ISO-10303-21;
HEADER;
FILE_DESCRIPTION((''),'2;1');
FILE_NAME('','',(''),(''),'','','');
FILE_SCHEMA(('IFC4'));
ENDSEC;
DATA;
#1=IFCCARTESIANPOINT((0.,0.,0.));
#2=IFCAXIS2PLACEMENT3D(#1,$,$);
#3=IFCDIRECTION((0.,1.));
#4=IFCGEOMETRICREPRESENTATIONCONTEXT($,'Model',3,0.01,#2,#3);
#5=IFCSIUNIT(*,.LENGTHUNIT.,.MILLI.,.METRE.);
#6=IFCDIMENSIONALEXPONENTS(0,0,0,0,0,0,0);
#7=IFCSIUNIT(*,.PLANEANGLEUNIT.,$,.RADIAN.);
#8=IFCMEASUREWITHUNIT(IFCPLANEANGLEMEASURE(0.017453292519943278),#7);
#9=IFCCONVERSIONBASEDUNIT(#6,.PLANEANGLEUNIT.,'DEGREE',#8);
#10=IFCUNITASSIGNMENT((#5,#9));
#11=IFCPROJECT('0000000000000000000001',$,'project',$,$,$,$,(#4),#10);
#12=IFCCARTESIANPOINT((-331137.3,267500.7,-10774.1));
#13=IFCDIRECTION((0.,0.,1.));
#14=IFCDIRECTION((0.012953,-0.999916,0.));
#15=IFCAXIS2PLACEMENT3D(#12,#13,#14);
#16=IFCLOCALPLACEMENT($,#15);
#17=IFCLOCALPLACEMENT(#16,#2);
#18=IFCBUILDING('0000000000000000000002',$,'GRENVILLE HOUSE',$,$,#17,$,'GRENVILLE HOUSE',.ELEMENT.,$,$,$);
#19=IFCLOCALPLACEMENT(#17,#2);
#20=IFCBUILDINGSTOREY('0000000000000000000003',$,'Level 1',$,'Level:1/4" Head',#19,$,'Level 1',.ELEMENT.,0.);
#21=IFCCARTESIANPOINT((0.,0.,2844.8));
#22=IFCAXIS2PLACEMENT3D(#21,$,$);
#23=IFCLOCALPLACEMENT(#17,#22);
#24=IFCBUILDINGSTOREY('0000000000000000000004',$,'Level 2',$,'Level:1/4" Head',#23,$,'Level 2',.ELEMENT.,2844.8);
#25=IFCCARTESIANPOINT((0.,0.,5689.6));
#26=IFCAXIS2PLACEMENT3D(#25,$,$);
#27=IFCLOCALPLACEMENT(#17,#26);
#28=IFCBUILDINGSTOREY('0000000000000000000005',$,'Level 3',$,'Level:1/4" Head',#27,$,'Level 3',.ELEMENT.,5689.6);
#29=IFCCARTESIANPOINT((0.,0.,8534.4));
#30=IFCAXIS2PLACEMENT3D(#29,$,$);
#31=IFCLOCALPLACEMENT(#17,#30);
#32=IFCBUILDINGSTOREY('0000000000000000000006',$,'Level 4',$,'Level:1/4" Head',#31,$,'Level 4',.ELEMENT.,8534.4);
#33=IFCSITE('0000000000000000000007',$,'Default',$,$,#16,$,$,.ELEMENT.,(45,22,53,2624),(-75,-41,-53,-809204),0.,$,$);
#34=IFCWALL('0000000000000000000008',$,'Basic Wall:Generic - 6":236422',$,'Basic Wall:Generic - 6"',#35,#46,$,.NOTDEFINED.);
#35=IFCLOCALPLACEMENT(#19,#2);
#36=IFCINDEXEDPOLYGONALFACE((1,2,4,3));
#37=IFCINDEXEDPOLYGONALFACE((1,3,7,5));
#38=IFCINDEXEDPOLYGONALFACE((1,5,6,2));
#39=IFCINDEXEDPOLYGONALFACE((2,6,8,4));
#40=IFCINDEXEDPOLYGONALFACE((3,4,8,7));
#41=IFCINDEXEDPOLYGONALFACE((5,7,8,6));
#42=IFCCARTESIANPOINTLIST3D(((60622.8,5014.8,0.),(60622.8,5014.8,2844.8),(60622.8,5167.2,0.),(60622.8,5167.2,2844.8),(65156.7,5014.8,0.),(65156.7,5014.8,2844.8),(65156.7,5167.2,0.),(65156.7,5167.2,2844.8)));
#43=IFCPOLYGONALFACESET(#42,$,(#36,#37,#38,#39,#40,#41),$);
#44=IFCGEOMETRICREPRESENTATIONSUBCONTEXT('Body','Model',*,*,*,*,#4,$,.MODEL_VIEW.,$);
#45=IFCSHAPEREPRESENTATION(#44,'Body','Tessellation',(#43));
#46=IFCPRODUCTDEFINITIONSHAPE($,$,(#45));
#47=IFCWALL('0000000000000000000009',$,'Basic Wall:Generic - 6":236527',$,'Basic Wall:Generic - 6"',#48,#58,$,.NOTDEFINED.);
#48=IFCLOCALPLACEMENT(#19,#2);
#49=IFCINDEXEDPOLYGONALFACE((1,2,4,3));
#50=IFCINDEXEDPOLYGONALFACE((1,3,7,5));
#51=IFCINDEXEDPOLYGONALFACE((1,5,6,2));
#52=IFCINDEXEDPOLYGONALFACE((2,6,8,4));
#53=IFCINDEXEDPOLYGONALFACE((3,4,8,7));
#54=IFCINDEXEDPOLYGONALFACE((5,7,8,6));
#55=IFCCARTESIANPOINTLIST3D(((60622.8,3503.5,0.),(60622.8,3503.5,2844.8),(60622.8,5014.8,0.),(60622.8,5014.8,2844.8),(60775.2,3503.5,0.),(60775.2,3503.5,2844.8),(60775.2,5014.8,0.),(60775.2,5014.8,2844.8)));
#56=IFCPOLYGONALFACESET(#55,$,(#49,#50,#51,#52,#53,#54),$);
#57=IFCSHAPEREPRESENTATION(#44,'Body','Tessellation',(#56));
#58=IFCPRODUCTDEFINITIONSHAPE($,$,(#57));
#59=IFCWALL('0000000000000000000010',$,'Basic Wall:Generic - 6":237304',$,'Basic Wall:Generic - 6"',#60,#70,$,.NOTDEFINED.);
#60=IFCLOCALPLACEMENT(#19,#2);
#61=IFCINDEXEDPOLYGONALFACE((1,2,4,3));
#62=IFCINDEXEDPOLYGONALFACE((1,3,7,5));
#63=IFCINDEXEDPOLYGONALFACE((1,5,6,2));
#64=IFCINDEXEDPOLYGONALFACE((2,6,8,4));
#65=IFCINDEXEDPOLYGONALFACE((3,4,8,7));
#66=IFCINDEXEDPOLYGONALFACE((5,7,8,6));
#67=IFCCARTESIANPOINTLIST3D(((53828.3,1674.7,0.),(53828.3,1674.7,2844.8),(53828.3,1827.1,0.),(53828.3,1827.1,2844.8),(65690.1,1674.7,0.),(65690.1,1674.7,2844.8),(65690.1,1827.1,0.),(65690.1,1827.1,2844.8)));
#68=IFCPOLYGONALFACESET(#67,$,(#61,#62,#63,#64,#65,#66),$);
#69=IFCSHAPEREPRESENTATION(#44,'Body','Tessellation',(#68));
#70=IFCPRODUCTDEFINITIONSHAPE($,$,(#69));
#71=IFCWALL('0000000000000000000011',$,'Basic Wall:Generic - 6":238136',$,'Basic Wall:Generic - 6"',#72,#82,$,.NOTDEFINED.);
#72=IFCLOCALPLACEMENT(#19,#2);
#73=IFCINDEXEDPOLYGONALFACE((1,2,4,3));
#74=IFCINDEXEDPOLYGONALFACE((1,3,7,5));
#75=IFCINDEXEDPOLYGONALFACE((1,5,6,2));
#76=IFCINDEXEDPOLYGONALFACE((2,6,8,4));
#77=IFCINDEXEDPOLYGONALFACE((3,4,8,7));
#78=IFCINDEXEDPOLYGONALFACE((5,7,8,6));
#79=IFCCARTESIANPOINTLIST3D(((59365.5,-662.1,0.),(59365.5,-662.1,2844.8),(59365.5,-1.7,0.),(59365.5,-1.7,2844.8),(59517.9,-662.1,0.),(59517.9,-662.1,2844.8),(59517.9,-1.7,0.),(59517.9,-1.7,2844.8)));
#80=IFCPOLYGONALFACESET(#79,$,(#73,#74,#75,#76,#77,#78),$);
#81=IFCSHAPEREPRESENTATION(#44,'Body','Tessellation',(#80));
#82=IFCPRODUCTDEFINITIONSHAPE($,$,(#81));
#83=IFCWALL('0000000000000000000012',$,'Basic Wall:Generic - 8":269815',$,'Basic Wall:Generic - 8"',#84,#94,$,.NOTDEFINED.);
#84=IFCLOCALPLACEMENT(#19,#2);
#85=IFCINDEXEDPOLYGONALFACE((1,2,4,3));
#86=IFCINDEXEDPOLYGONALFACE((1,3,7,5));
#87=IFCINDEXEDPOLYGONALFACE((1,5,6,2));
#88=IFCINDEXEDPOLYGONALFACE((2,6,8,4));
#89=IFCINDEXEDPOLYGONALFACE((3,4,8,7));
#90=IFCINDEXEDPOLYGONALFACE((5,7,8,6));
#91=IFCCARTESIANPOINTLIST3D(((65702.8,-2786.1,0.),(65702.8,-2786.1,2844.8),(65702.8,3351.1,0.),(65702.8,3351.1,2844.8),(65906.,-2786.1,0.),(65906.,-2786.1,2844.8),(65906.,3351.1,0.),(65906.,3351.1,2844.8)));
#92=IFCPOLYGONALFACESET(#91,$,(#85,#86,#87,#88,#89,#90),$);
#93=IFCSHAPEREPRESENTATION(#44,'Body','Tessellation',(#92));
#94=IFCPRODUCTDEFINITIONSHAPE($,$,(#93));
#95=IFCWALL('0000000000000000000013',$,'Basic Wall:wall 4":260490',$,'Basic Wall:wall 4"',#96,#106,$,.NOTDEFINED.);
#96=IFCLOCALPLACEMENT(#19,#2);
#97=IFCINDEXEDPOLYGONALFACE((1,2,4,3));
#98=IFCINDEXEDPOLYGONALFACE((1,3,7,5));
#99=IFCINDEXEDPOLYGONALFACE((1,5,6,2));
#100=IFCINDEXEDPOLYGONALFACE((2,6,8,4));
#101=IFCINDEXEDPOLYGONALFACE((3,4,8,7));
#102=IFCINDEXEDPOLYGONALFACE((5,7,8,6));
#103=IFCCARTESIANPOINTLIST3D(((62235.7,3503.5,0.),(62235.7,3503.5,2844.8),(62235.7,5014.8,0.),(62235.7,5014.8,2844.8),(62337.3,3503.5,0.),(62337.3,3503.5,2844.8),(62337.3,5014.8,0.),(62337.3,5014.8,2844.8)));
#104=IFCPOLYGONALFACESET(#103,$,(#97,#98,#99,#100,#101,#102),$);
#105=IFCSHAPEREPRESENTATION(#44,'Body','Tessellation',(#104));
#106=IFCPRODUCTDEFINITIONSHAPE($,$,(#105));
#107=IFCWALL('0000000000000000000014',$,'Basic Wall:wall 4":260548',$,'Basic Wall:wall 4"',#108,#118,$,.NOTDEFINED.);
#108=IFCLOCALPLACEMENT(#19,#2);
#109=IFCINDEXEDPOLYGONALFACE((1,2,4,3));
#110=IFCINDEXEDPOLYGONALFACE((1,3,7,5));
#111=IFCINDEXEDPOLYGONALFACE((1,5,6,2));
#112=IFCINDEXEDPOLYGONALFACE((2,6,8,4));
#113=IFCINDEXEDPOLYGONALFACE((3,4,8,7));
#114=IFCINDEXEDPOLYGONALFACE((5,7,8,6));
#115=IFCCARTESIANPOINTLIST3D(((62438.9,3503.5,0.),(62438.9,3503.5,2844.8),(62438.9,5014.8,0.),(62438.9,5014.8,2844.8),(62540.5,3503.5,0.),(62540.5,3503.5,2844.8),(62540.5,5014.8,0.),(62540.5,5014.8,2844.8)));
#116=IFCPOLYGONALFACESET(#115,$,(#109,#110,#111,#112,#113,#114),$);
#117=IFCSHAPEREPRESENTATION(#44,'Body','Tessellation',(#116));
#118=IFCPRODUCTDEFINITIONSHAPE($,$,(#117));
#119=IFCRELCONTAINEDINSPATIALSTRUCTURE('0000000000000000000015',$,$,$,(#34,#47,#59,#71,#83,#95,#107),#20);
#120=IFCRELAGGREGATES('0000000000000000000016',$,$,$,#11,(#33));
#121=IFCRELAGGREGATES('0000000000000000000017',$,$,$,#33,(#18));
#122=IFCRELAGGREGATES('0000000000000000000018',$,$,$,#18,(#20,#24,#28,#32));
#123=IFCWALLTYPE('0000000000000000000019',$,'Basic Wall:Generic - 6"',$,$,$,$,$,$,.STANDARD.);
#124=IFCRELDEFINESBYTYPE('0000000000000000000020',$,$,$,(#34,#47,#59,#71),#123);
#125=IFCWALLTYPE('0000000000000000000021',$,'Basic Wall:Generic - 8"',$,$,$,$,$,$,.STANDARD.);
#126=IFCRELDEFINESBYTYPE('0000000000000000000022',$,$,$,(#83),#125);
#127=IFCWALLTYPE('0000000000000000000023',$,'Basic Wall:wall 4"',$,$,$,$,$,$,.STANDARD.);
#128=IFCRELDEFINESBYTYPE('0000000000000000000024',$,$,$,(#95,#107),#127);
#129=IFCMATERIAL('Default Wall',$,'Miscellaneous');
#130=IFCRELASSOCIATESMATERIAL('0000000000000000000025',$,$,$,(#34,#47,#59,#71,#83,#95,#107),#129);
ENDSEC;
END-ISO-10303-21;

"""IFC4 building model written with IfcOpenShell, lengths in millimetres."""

from ifc_helpers import new_model, entity, si_unit, converted_unit, direction, frame, origin, place, context, subcontext, project, spatial, indexed_curve, outline, extrude, material, type_object, element, save


model = new_model("IFC4")

# Units and contexts
model_context = context("Model", 3, precision=0.01, world=origin(), true_north=direction((0.0, 1.0)))
body_context = subcontext(model_context, "Body", "Model", "MODEL_VIEW")
ifc_project = project(units=[si_unit("LENGTHUNIT", "METRE", prefix="MILLI"), converted_unit("PLANEANGLEUNIT", "DEGREE", entity("IfcPlaneAngleMeasure", 0.017453292519943278), si_unit("PLANEANGLEUNIT", "RADIAN"), dimensions=[0, 0, 0, 0, 0, 0, 0])], contexts=[model_context])

# Site, building, storey
site_placement = place(None, frame((-331137.3, 267500.7, -10774.1), z_axis=(0.0, 0.0, 1.0), x_axis=(0.012953, -0.999916, 0.0)))
site = spatial("IfcSite", under=ifc_project, at=site_placement, Name="Default", CompositionType="ELEMENT", RefLatitude=(45, 22, 53, 2624), RefLongitude=(-75, -41, -53, -809204), RefElevation=0.0)
building_placement = place(site_placement, origin())
building = spatial("IfcBuilding", under=site, at=building_placement, Name="GRENVILLE HOUSE", LongName="GRENVILLE HOUSE", CompositionType="ELEMENT")
storey_1_placement = place(building_placement, origin())
storey_1 = spatial("IfcBuildingStorey", under=building, at=storey_1_placement, Name="Level 1", ObjectType="Level:1/4\" Head", LongName="Level 1", CompositionType="ELEMENT", Elevation=0.0)

# Shared definitions
storey_2_placement = place(building_placement, frame((0.0, 0.0, 2844.8)))
storey_2 = spatial("IfcBuildingStorey", under=building, at=storey_2_placement, Name="Level 2", ObjectType="Level:1/4\" Head", LongName="Level 2", CompositionType="ELEMENT", Elevation=2844.8)

# Shared definitions
storey_3_placement = place(building_placement, frame((0.0, 0.0, 5689.6)))
storey_3 = spatial("IfcBuildingStorey", under=building, at=storey_3_placement, Name="Level 3", ObjectType="Level:1/4\" Head", LongName="Level 3", CompositionType="ELEMENT", Elevation=5689.6)

# Shared definitions
storey_4_placement = place(building_placement, frame((0.0, 0.0, 8534.4)))
storey_4 = spatial("IfcBuildingStorey", under=building, at=storey_4_placement, Name="Level 4", ObjectType="Level:1/4\" Head", LongName="Level 4", CompositionType="ELEMENT", Elevation=8534.4)

# Walls
ifc_material_1 = material(Name="Default Wall", Category="Miscellaneous")
wall_type_1 = type_object("IfcWallType", Name="Basic Wall:Generic - 6\"", PredefinedType="STANDARD")
wall_1_placement = place(storey_1_placement, frame((65156.7, 5091.0, 0.0), z_axis=(0.0, 0.0, 1.0), x_axis=(-1.0, 0.0, 0.0)))
element("IfcWall", 1, at=wall_1_placement, inside=storey_1, type_object=wall_type_1, material=ifc_material_1, Name="Basic Wall:Generic - 6\":236422", ObjectType="Basic Wall:Generic - 6\"", PredefinedType="NOTDEFINED", context=body_context, shape_type="SweptSolid", body=[
    extrude(outline(indexed_curve([(4533.9, 76.2), (0.0, 76.2), (0.0, -76.2), (4533.9, -76.2), (4533.9, 76.2)], self_intersect=False)), origin(), (0.0, 0.0, 1.0), 2844.8),
])
wall_2_placement = place(storey_1_placement, frame((60699.0, 5014.8, 0.0), z_axis=(0.0, 0.0, 1.0), x_axis=(0.0, -1.0, 0.0)))
element("IfcWall", 2, at=wall_2_placement, inside=storey_1, type_object=wall_type_1, material=ifc_material_1, Name="Basic Wall:Generic - 6\":236527", ObjectType="Basic Wall:Generic - 6\"", PredefinedType="NOTDEFINED", context=body_context, shape_type="SweptSolid", body=[
    extrude(outline(indexed_curve([(1511.3, 76.2), (0.0, 76.2), (0.0, -76.2), (1511.3, -76.2), (1511.3, 76.2)], self_intersect=False)), origin(), (0.0, 0.0, 1.0), 2844.8),
])
wall_3_placement = place(storey_1_placement, frame((65690.1, 1750.9, 0.0), z_axis=(0.0, 0.0, 1.0), x_axis=(-1.0, 0.0, 0.0)))
element("IfcWall", 3, at=wall_3_placement, inside=storey_1, type_object=wall_type_1, material=ifc_material_1, Name="Basic Wall:Generic - 6\":237304", ObjectType="Basic Wall:Generic - 6\"", PredefinedType="NOTDEFINED", context=body_context, shape_type="SweptSolid", body=[
    extrude(outline(indexed_curve([(11861.8, 76.2), (0.0, 76.2), (0.0, -76.2), (11861.8, -76.2), (11861.8, 76.2)], self_intersect=False)), origin(), (0.0, 0.0, 1.0), 2844.8),
])
wall_4_placement = place(storey_1_placement, frame((59441.7, -662.1, 0.0), z_axis=(0.0, 0.0, 1.0), x_axis=(0.0, 1.0, 0.0)))
element("IfcWall", 4, at=wall_4_placement, inside=storey_1, type_object=wall_type_1, material=ifc_material_1, Name="Basic Wall:Generic - 6\":238136", ObjectType="Basic Wall:Generic - 6\"", PredefinedType="NOTDEFINED", context=body_context, shape_type="SweptSolid", body=[
    extrude(outline(indexed_curve([(660.4, 76.2), (0.0, 76.2), (0.0, -76.2), (660.4, -76.2), (660.4, 76.2)], self_intersect=False)), origin(), (0.0, 0.0, 1.0), 2844.8),
])
wall_type_2 = type_object("IfcWallType", Name="Basic Wall:Generic - 8\"", PredefinedType="STANDARD")
wall_5_placement = place(storey_1_placement, frame((65804.4, -2786.1, 0.0), z_axis=(0.0, 0.0, 1.0), x_axis=(0.0, 1.0, 0.0)))
element("IfcWall", 5, at=wall_5_placement, inside=storey_1, type_object=wall_type_2, material=ifc_material_1, Name="Basic Wall:Generic - 8\":269815", ObjectType="Basic Wall:Generic - 8\"", PredefinedType="NOTDEFINED", context=body_context, shape_type="SweptSolid", body=[
    extrude(outline(indexed_curve([(6137.3, 101.6), (0.0, 101.6), (0.0, -101.6), (6137.3, -101.6), (6137.3, 101.6)], self_intersect=False)), origin(), (0.0, 0.0, 1.0), 2844.8),
])
wall_type_3 = type_object("IfcWallType", Name="Basic Wall:wall 4\"", PredefinedType="STANDARD")
wall_6_placement = place(storey_1_placement, frame((62286.5, 3503.5, 0.0), z_axis=(0.0, 0.0, 1.0), x_axis=(0.0, 1.0, 0.0)))
element("IfcWall", 6, at=wall_6_placement, inside=storey_1, type_object=wall_type_3, material=ifc_material_1, Name="Basic Wall:wall 4\":260490", ObjectType="Basic Wall:wall 4\"", PredefinedType="NOTDEFINED", context=body_context, shape_type="SweptSolid", body=[
    extrude(outline(indexed_curve([(1511.3, 50.8), (0.0, 50.8), (0.0, -50.8), (1511.3, -50.8), (1511.3, 50.8)], self_intersect=False)), origin(), (0.0, 0.0, 1.0), 2844.8),
])
wall_7_placement = place(storey_1_placement, frame((62489.7, 5014.8, 0.0), z_axis=(0.0, 0.0, 1.0), x_axis=(0.0, -1.0, 0.0)))
element("IfcWall", 7, at=wall_7_placement, inside=storey_1, type_object=wall_type_3, material=ifc_material_1, Name="Basic Wall:wall 4\":260548", ObjectType="Basic Wall:wall 4\"", PredefinedType="NOTDEFINED", context=body_context, shape_type="SweptSolid", body=[
    extrude(outline(indexed_curve([(1511.3, 50.8), (0.0, 50.8), (0.0, -50.8), (1511.3, -50.8), (1511.3, 50.8)], self_intersect=False)), origin(), (0.0, 0.0, 1.0), 2844.8),
])

save(model, "model.ifc")
